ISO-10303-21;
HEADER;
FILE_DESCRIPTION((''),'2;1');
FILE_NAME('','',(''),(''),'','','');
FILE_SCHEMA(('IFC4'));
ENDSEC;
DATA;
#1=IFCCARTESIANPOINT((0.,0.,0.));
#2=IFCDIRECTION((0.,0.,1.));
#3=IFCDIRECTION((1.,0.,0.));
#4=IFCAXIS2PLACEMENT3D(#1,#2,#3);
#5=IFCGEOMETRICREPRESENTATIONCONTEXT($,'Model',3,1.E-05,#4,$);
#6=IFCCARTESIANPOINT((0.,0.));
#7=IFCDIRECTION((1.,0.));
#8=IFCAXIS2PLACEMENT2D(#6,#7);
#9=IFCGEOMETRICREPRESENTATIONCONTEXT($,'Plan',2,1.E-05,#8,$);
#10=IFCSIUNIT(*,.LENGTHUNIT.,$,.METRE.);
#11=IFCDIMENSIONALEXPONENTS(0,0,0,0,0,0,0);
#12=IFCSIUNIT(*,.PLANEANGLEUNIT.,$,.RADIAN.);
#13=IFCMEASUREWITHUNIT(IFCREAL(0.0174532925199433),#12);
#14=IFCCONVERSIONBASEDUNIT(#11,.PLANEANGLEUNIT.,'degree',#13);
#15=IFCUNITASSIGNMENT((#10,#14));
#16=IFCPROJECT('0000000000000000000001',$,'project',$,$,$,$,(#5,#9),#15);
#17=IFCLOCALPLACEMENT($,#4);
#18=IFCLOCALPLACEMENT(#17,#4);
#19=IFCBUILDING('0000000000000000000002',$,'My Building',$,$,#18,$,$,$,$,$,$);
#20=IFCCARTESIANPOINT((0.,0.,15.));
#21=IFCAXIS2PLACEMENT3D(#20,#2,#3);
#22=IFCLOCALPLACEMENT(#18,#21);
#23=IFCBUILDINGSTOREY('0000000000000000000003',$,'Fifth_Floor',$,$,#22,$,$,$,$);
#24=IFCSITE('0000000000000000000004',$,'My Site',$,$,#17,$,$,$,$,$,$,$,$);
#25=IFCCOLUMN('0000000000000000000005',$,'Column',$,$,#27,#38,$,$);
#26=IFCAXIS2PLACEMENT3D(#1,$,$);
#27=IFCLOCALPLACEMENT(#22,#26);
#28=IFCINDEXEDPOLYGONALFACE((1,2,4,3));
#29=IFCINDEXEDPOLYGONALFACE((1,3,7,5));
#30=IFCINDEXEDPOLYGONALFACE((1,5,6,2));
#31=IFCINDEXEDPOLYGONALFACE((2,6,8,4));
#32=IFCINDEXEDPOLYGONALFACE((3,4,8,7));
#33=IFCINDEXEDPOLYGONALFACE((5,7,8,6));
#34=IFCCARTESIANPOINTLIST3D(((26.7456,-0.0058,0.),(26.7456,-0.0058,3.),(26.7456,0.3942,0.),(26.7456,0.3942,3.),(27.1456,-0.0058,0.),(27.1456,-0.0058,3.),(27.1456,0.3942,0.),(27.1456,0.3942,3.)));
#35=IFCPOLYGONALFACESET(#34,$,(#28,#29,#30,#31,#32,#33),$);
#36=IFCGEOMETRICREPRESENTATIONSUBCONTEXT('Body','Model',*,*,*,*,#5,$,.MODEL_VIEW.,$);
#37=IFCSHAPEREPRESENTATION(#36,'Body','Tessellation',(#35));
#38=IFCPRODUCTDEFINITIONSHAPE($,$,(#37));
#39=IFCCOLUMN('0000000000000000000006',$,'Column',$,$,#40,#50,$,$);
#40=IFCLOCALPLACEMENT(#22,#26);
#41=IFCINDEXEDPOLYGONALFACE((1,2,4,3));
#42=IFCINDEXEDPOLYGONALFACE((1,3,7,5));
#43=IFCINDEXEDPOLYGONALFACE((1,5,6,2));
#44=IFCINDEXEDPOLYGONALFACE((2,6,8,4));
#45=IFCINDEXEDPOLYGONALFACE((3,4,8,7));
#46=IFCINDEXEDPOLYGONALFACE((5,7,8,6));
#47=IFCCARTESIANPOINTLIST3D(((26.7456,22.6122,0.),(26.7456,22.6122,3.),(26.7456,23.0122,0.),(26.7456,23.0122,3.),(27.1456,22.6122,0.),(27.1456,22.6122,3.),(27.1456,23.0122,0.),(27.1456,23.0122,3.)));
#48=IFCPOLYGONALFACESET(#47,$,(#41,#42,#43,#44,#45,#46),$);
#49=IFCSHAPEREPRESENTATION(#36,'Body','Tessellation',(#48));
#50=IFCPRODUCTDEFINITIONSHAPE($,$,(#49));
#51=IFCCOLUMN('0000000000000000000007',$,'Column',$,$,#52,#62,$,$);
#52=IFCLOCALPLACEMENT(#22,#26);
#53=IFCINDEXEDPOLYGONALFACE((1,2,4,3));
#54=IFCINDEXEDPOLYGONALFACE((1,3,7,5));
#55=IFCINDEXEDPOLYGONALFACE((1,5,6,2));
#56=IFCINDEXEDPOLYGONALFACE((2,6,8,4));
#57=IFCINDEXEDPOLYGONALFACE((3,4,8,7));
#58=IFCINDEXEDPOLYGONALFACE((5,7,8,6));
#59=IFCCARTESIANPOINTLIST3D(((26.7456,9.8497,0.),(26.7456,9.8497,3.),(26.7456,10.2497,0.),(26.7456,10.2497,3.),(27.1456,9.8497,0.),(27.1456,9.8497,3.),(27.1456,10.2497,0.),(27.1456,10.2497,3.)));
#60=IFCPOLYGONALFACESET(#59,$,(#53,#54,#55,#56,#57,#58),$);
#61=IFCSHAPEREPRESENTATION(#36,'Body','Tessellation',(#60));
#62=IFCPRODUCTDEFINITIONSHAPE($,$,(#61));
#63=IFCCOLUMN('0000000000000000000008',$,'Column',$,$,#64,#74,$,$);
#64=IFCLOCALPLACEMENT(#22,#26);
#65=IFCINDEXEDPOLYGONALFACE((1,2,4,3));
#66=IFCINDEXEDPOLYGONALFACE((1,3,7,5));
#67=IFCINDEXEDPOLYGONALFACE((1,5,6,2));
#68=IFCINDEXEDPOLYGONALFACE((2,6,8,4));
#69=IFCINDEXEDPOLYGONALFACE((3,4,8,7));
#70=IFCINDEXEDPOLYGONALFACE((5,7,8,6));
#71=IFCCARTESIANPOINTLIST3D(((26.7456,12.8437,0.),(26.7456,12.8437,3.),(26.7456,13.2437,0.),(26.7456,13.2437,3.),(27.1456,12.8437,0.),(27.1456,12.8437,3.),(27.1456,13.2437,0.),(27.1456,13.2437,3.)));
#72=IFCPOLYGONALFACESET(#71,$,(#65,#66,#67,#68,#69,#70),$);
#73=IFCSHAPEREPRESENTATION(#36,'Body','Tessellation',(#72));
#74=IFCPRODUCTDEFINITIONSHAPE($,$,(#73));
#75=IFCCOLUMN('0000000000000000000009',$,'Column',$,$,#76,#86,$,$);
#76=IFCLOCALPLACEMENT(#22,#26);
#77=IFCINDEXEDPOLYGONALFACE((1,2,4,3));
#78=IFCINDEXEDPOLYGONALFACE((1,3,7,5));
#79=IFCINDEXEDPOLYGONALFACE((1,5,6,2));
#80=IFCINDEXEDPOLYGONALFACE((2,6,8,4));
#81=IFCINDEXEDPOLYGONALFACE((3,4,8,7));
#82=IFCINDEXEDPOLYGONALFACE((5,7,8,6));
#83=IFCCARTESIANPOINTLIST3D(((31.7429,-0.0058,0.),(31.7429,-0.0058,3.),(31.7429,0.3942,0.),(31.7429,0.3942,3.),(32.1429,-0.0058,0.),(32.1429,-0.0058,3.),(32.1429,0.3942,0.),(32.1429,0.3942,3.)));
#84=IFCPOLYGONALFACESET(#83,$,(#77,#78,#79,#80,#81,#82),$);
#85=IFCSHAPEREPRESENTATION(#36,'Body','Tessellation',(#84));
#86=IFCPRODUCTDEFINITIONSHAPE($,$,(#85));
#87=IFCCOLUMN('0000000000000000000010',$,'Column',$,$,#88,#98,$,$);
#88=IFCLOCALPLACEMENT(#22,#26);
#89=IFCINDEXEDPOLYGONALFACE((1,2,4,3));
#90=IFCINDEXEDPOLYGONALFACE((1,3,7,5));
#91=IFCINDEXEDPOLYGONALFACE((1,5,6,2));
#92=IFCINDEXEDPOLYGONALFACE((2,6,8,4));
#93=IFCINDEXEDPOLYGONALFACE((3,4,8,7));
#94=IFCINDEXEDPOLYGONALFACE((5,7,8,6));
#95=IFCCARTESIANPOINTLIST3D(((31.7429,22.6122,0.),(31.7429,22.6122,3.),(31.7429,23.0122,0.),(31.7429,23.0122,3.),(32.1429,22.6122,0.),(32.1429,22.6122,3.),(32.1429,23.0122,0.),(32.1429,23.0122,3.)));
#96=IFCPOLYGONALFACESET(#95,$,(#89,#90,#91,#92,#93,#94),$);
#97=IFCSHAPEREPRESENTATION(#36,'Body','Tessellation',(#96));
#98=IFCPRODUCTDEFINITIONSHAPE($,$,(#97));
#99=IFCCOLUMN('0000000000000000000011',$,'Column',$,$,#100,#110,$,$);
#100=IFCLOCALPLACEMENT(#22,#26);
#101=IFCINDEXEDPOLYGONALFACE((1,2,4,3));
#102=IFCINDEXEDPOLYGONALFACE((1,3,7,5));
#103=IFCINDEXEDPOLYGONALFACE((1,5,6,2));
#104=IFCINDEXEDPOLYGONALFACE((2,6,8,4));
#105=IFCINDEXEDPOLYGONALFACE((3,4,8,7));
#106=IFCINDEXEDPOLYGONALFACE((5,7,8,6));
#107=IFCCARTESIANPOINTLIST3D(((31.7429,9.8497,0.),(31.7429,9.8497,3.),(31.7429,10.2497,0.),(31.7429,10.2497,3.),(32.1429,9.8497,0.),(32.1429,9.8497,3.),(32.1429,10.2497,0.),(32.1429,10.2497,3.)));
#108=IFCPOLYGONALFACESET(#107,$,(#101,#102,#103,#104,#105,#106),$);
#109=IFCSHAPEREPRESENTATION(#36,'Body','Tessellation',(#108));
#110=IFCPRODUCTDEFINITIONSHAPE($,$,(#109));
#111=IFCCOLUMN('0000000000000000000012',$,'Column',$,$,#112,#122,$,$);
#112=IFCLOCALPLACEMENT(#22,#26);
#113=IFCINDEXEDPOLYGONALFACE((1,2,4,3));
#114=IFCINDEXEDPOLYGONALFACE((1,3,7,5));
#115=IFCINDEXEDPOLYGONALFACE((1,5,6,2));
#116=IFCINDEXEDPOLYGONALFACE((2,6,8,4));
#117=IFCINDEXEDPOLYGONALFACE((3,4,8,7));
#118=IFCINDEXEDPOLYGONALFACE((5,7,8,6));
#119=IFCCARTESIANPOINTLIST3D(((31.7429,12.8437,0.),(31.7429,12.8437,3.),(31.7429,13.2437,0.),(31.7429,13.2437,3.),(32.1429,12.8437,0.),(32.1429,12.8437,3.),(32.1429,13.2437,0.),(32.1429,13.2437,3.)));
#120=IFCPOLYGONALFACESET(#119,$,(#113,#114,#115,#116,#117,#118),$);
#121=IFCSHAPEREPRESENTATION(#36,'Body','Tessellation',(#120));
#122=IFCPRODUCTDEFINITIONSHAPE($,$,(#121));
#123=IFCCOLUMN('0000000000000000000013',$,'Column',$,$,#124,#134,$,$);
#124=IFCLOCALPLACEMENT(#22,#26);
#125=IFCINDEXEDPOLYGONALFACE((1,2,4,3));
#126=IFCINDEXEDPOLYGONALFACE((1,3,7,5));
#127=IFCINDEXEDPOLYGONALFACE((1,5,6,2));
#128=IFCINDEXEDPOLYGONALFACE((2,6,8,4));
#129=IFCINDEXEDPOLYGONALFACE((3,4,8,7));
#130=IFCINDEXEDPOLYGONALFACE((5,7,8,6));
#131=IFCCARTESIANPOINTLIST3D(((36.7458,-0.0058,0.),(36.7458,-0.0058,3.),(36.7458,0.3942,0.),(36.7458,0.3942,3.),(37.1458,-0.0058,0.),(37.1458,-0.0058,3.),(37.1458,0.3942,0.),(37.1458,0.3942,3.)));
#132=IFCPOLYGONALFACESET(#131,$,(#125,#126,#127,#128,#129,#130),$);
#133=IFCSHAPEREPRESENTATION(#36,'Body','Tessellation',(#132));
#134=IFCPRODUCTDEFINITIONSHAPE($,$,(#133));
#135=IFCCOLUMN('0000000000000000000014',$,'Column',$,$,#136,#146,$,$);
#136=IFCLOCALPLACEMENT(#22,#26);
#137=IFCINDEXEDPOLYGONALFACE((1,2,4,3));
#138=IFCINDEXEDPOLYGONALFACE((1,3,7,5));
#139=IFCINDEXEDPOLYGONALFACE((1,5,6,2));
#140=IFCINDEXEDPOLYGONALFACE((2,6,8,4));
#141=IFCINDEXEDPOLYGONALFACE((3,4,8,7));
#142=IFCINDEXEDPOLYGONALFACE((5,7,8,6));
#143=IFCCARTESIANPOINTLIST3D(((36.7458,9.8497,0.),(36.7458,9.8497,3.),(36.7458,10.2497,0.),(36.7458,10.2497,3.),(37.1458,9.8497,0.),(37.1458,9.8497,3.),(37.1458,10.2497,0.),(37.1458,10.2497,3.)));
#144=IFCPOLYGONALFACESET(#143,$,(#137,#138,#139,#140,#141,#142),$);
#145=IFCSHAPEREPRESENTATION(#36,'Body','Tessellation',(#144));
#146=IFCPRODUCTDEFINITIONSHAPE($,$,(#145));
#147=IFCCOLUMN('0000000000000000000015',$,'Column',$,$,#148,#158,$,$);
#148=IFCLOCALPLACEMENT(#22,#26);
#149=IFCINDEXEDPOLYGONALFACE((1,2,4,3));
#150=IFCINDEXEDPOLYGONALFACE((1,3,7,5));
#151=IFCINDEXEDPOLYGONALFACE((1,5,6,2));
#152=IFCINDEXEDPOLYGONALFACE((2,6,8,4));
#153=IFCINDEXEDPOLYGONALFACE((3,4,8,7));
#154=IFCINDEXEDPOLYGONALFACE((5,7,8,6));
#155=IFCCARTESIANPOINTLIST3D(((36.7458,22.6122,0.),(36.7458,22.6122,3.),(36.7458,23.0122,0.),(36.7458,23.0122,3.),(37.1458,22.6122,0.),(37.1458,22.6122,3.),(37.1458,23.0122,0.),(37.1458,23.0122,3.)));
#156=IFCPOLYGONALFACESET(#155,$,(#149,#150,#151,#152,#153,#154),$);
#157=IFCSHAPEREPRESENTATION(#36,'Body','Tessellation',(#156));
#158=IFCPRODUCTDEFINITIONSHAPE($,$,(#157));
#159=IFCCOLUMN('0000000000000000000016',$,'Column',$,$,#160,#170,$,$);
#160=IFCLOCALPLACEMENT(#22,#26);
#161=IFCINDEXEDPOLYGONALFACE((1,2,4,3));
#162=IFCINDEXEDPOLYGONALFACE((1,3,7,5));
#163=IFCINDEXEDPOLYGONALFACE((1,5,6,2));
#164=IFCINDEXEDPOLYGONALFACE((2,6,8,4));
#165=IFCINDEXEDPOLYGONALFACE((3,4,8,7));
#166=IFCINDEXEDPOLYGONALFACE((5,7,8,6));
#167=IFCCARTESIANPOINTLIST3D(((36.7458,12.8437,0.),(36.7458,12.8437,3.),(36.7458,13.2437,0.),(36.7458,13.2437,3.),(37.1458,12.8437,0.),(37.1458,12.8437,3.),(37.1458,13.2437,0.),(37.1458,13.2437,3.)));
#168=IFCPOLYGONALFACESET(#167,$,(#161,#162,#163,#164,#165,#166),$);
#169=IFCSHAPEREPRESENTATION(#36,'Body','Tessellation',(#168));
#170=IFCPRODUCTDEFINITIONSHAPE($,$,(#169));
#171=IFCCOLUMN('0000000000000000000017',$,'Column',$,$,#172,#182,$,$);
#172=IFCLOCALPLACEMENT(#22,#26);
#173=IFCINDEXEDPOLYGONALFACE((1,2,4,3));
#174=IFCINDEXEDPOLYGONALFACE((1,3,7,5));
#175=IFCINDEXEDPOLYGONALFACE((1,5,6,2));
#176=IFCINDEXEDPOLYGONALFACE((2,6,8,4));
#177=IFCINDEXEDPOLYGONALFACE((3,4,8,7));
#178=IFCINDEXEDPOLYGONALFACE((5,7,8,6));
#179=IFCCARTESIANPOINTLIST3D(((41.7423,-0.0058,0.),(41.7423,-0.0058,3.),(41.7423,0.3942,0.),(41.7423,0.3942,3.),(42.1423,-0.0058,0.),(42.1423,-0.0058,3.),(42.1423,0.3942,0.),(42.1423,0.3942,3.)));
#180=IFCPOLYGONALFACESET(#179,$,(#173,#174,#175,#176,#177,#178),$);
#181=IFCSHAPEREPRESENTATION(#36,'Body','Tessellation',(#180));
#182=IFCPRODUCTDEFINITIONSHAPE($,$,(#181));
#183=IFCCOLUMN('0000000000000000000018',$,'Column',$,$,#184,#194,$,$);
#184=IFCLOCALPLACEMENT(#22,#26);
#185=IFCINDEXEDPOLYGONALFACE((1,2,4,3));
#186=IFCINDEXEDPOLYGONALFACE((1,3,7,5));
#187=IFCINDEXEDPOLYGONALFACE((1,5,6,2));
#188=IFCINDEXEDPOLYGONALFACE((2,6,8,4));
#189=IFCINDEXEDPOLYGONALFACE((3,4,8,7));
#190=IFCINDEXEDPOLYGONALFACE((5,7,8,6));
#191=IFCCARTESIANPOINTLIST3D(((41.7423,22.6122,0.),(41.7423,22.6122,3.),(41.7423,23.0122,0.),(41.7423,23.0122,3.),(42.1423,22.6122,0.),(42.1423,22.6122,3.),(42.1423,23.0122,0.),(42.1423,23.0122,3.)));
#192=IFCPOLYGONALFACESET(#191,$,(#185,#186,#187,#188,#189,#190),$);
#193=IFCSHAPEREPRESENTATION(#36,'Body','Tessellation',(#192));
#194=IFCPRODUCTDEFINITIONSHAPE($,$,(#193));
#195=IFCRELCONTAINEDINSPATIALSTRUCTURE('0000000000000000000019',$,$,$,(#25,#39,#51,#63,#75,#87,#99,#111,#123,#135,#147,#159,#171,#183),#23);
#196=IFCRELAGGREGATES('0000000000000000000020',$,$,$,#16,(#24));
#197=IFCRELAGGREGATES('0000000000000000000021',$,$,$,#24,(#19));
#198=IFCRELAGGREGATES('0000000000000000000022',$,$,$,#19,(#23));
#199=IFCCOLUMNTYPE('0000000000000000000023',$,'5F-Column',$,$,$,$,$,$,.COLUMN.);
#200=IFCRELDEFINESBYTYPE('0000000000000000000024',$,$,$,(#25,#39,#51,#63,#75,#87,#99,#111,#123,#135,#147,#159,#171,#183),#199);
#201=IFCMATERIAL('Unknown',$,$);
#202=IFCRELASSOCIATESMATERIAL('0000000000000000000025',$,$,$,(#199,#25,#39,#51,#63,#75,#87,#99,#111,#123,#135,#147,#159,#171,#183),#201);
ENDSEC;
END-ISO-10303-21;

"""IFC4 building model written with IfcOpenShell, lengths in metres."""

from ifc_helpers import new_model, entity, si_unit, converted_unit, frame, origin_with_axes, origin_2d_with_axis, place, context, subcontext, project, spatial, rectangle, extrude, material, material_profile, profile_set, profile_usage, type_object, element, save


model = new_model("IFC4")

# Units and contexts
model_context = context("Model", 3, precision=1e-05, world=origin_with_axes())
plan_context = context("Plan", 2, precision=1e-05, world=origin_2d_with_axis())
body_context = subcontext(model_context, "Body", "Model", "MODEL_VIEW")
ifc_project = project(units=[si_unit("LENGTHUNIT", "METRE"), converted_unit("PLANEANGLEUNIT", "degree", entity("IfcReal", 0.0174532925199433), si_unit("PLANEANGLEUNIT", "RADIAN"), dimensions=[0, 0, 0, 0, 0, 0, 0])], contexts=[model_context, plan_context])

# Site, building, storey
site_placement = place(None, origin_with_axes())
site = spatial("IfcSite", under=ifc_project, at=site_placement, Name="My Site")
building_placement = place(site_placement, origin_with_axes())
building = spatial("IfcBuilding", under=site, at=building_placement, Name="My Building")
storey_placement = place(building_placement, frame((0.0, 0.0, 15.0), z_axis=(0.0, 0.0, 1.0), x_axis=(1.0, 0.0, 0.0)))
storey = spatial("IfcBuildingStorey", under=building, at=storey_placement, Name="Fifth_Floor")

# Columns
ifc_material = material(Name="Unknown")
ifc_material_profile_1 = material_profile(ifc_material, rectangle(XDim=0.4, YDim=0.4))
ifc_profile_set_1 = profile_set([ifc_material_profile_1])
ifc_profile_usage_1 = profile_usage(ifc_profile_set_1, cardinal=8)
column_type = type_object("IfcColumnType", Name="5F-Column", PredefinedType="COLUMN", material=ifc_profile_set_1)
column_1_placement = place(storey_placement, frame((26.9456, 0.3942, 0.0), z_axis=(0.0, 0.0, 1.0), x_axis=(1.0, 0.0, 0.0)))
element("IfcColumn", 1, at=column_1_placement, inside=storey, type_object=column_type, material=ifc_profile_usage_1, Name="Column", context=body_context, shape_type="SweptSolid", body=[
    extrude(rectangle(XDim=0.4, YDim=0.4), frame((0.0, -0.2, 0.0), z_axis=(0.0, 0.0, 1.0), x_axis=(1.0, 0.0, 0.0)), (0.0, 0.0, 1.0), 3.0),
])
ifc_profile_usage_2 = profile_usage(ifc_profile_set_1, cardinal=8)
column_2_placement = place(storey_placement, frame((26.9456, 23.0122, 0.0), z_axis=(0.0, 0.0, 1.0), x_axis=(1.0, 0.0, 0.0)))
element("IfcColumn", 2, at=column_2_placement, inside=storey, type_object=column_type, material=ifc_profile_usage_2, Name="Column", context=body_context, shape_type="SweptSolid", body=[
    extrude(rectangle(XDim=0.4, YDim=0.4), frame((0.0, -0.2, 0.0), z_axis=(0.0, 0.0, 1.0), x_axis=(1.0, 0.0, 0.0)), (0.0, 0.0, 1.0), 3.0),
])
ifc_profile_usage_3 = profile_usage(ifc_profile_set_1, cardinal=8)
column_3_placement = place(storey_placement, frame((26.9456, 10.2497, 0.0), z_axis=(0.0, 0.0, 1.0), x_axis=(1.0, 0.0, 0.0)))
element("IfcColumn", 3, at=column_3_placement, inside=storey, type_object=column_type, material=ifc_profile_usage_3, Name="Column", context=body_context, shape_type="SweptSolid", body=[
    extrude(rectangle(XDim=0.4, YDim=0.4), frame((0.0, -0.2, 0.0), z_axis=(0.0, 0.0, 1.0), x_axis=(1.0, 0.0, 0.0)), (0.0, 0.0, 1.0), 3.0),
])
ifc_profile_usage_4 = profile_usage(ifc_profile_set_1, cardinal=8)
column_4_placement = place(storey_placement, frame((26.9456, 13.2437, 0.0), z_axis=(0.0, 0.0, 1.0), x_axis=(1.0, 0.0, 0.0)))
element("IfcColumn", 4, at=column_4_placement, inside=storey, type_object=column_type, material=ifc_profile_usage_4, Name="Column", context=body_context, shape_type="SweptSolid", body=[
    extrude(rectangle(XDim=0.4, YDim=0.4), frame((0.0, -0.2, 0.0), z_axis=(0.0, 0.0, 1.0), x_axis=(1.0, 0.0, 0.0)), (0.0, 0.0, 1.0), 3.0),
])
ifc_profile_usage_5 = profile_usage(ifc_profile_set_1, cardinal=8)
column_5_placement = place(storey_placement, frame((31.9429, 0.3942, 0.0), z_axis=(0.0, 0.0, 1.0), x_axis=(1.0, 0.0, 0.0)))
element("IfcColumn", 5, at=column_5_placement, inside=storey, type_object=column_type, material=ifc_profile_usage_5, Name="Column", context=body_context, shape_type="SweptSolid", body=[
    extrude(rectangle(XDim=0.4, YDim=0.4), frame((0.0, -0.2, 0.0), z_axis=(0.0, 0.0, 1.0), x_axis=(1.0, 0.0, 0.0)), (0.0, 0.0, 1.0), 3.0),
])
ifc_profile_usage_6 = profile_usage(ifc_profile_set_1, cardinal=8)
column_6_placement = place(storey_placement, frame((31.9429, 23.0122, 0.0), z_axis=(0.0, 0.0, 1.0), x_axis=(1.0, 0.0, 0.0)))
element("IfcColumn", 6, at=column_6_placement, inside=storey, type_object=column_type, material=ifc_profile_usage_6, Name="Column", context=body_context, shape_type="SweptSolid", body=[
    extrude(rectangle(XDim=0.4, YDim=0.4), frame((0.0, -0.2, 0.0), z_axis=(0.0, 0.0, 1.0), x_axis=(1.0, 0.0, 0.0)), (0.0, 0.0, 1.0), 3.0),
])
ifc_profile_usage_7 = profile_usage(ifc_profile_set_1, cardinal=8)
column_7_placement = place(storey_placement, frame((31.9429, 10.2497, 0.0), z_axis=(0.0, 0.0, 1.0), x_axis=(1.0, 0.0, 0.0)))
element("IfcColumn", 7, at=column_7_placement, inside=storey, type_object=column_type, material=ifc_profile_usage_7, Name="Column", context=body_context, shape_type="SweptSolid", body=[
    extrude(rectangle(XDim=0.4, YDim=0.4), frame((0.0, -0.2, 0.0), z_axis=(0.0, 0.0, 1.0), x_axis=(1.0, 0.0, 0.0)), (0.0, 0.0, 1.0), 3.0),
])
ifc_profile_usage_8 = profile_usage(ifc_profile_set_1, cardinal=8)
column_8_placement = place(storey_placement, frame((31.9429, 13.2437, 0.0), z_axis=(0.0, 0.0, 1.0), x_axis=(1.0, 0.0, 0.0)))
element("IfcColumn", 8, at=column_8_placement, inside=storey, type_object=column_type, material=ifc_profile_usage_8, Name="Column", context=body_context, shape_type="SweptSolid", body=[
    extrude(rectangle(XDim=0.4, YDim=0.4), frame((0.0, -0.2, 0.0), z_axis=(0.0, 0.0, 1.0), x_axis=(1.0, 0.0, 0.0)), (0.0, 0.0, 1.0), 3.0),
])
ifc_profile_usage_9 = profile_usage(ifc_profile_set_1, cardinal=8)
column_9_placement = place(storey_placement, frame((36.9458, 0.3942, 0.0), z_axis=(0.0, 0.0, 1.0), x_axis=(1.0, 0.0, 0.0)))
element("IfcColumn", 9, at=column_9_placement, inside=storey, type_object=column_type, material=ifc_profile_usage_9, Name="Column", context=body_context, shape_type="SweptSolid", body=[
    extrude(rectangle(XDim=0.4, YDim=0.4), frame((0.0, -0.2, 0.0), z_axis=(0.0, 0.0, 1.0), x_axis=(1.0, 0.0, 0.0)), (0.0, 0.0, 1.0), 3.0),
])
ifc_profile_usage_10 = profile_usage(ifc_profile_set_1, cardinal=8)
column_10_placement = place(storey_placement, frame((36.9458, 10.2497, 0.0), z_axis=(0.0, 0.0, 1.0), x_axis=(1.0, 0.0, 0.0)))
element("IfcColumn", 10, at=column_10_placement, inside=storey, type_object=column_type, material=ifc_profile_usage_10, Name="Column", context=body_context, shape_type="SweptSolid", body=[
    extrude(rectangle(XDim=0.4, YDim=0.4), frame((0.0, -0.2, 0.0), z_axis=(0.0, 0.0, 1.0), x_axis=(1.0, 0.0, 0.0)), (0.0, 0.0, 1.0), 3.0),
])
ifc_profile_usage_11 = profile_usage(ifc_profile_set_1, cardinal=8)
column_11_placement = place(storey_placement, frame((36.9458, 23.0122, 0.0), z_axis=(0.0, 0.0, 1.0), x_axis=(1.0, 0.0, 0.0)))
element("IfcColumn", 11, at=column_11_placement, inside=storey, type_object=column_type, material=ifc_profile_usage_11, Name="Column", context=body_context, shape_type="SweptSolid", body=[
    extrude(rectangle(XDim=0.4, YDim=0.4), frame((0.0, -0.2, 0.0), z_axis=(0.0, 0.0, 1.0), x_axis=(1.0, 0.0, 0.0)), (0.0, 0.0, 1.0), 3.0),
])
ifc_profile_usage_12 = profile_usage(ifc_profile_set_1, cardinal=8)
column_12_placement = place(storey_placement, frame((36.9458, 13.2437, 0.0), z_axis=(0.0, 0.0, 1.0), x_axis=(1.0, 0.0, 0.0)))
element("IfcColumn", 12, at=column_12_placement, inside=storey, type_object=column_type, material=ifc_profile_usage_12, Name="Column", context=body_context, shape_type="SweptSolid", body=[
    extrude(rectangle(XDim=0.4, YDim=0.4), frame((0.0, -0.2, 0.0), z_axis=(0.0, 0.0, 1.0), x_axis=(1.0, 0.0, 0.0)), (0.0, 0.0, 1.0), 3.0),
])
ifc_profile_usage_13 = profile_usage(ifc_profile_set_1, cardinal=8)
column_13_placement = place(storey_placement, frame((41.9423, 0.3942, 0.0), z_axis=(0.0, 0.0, 1.0), x_axis=(1.0, 0.0, 0.0)))
element("IfcColumn", 13, at=column_13_placement, inside=storey, type_object=column_type, material=ifc_profile_usage_13, Name="Column", context=body_context, shape_type="SweptSolid", body=[
    extrude(rectangle(XDim=0.4, YDim=0.4), frame((0.0, -0.2, 0.0), z_axis=(0.0, 0.0, 1.0), x_axis=(1.0, 0.0, 0.0)), (0.0, 0.0, 1.0), 3.0),
])
ifc_profile_usage_14 = profile_usage(ifc_profile_set_1, cardinal=8)
column_14_placement = place(storey_placement, frame((41.9423, 23.0122, 0.0), z_axis=(0.0, 0.0, 1.0), x_axis=(1.0, 0.0, 0.0)))
element("IfcColumn", 14, at=column_14_placement, inside=storey, type_object=column_type, material=ifc_profile_usage_14, Name="Column", context=body_context, shape_type="SweptSolid", body=[
    extrude(rectangle(XDim=0.4, YDim=0.4), frame((0.0, -0.2, 0.0), z_axis=(0.0, 0.0, 1.0), x_axis=(1.0, 0.0, 0.0)), (0.0, 0.0, 1.0), 3.0),
])

save(model, "model.ifc")
